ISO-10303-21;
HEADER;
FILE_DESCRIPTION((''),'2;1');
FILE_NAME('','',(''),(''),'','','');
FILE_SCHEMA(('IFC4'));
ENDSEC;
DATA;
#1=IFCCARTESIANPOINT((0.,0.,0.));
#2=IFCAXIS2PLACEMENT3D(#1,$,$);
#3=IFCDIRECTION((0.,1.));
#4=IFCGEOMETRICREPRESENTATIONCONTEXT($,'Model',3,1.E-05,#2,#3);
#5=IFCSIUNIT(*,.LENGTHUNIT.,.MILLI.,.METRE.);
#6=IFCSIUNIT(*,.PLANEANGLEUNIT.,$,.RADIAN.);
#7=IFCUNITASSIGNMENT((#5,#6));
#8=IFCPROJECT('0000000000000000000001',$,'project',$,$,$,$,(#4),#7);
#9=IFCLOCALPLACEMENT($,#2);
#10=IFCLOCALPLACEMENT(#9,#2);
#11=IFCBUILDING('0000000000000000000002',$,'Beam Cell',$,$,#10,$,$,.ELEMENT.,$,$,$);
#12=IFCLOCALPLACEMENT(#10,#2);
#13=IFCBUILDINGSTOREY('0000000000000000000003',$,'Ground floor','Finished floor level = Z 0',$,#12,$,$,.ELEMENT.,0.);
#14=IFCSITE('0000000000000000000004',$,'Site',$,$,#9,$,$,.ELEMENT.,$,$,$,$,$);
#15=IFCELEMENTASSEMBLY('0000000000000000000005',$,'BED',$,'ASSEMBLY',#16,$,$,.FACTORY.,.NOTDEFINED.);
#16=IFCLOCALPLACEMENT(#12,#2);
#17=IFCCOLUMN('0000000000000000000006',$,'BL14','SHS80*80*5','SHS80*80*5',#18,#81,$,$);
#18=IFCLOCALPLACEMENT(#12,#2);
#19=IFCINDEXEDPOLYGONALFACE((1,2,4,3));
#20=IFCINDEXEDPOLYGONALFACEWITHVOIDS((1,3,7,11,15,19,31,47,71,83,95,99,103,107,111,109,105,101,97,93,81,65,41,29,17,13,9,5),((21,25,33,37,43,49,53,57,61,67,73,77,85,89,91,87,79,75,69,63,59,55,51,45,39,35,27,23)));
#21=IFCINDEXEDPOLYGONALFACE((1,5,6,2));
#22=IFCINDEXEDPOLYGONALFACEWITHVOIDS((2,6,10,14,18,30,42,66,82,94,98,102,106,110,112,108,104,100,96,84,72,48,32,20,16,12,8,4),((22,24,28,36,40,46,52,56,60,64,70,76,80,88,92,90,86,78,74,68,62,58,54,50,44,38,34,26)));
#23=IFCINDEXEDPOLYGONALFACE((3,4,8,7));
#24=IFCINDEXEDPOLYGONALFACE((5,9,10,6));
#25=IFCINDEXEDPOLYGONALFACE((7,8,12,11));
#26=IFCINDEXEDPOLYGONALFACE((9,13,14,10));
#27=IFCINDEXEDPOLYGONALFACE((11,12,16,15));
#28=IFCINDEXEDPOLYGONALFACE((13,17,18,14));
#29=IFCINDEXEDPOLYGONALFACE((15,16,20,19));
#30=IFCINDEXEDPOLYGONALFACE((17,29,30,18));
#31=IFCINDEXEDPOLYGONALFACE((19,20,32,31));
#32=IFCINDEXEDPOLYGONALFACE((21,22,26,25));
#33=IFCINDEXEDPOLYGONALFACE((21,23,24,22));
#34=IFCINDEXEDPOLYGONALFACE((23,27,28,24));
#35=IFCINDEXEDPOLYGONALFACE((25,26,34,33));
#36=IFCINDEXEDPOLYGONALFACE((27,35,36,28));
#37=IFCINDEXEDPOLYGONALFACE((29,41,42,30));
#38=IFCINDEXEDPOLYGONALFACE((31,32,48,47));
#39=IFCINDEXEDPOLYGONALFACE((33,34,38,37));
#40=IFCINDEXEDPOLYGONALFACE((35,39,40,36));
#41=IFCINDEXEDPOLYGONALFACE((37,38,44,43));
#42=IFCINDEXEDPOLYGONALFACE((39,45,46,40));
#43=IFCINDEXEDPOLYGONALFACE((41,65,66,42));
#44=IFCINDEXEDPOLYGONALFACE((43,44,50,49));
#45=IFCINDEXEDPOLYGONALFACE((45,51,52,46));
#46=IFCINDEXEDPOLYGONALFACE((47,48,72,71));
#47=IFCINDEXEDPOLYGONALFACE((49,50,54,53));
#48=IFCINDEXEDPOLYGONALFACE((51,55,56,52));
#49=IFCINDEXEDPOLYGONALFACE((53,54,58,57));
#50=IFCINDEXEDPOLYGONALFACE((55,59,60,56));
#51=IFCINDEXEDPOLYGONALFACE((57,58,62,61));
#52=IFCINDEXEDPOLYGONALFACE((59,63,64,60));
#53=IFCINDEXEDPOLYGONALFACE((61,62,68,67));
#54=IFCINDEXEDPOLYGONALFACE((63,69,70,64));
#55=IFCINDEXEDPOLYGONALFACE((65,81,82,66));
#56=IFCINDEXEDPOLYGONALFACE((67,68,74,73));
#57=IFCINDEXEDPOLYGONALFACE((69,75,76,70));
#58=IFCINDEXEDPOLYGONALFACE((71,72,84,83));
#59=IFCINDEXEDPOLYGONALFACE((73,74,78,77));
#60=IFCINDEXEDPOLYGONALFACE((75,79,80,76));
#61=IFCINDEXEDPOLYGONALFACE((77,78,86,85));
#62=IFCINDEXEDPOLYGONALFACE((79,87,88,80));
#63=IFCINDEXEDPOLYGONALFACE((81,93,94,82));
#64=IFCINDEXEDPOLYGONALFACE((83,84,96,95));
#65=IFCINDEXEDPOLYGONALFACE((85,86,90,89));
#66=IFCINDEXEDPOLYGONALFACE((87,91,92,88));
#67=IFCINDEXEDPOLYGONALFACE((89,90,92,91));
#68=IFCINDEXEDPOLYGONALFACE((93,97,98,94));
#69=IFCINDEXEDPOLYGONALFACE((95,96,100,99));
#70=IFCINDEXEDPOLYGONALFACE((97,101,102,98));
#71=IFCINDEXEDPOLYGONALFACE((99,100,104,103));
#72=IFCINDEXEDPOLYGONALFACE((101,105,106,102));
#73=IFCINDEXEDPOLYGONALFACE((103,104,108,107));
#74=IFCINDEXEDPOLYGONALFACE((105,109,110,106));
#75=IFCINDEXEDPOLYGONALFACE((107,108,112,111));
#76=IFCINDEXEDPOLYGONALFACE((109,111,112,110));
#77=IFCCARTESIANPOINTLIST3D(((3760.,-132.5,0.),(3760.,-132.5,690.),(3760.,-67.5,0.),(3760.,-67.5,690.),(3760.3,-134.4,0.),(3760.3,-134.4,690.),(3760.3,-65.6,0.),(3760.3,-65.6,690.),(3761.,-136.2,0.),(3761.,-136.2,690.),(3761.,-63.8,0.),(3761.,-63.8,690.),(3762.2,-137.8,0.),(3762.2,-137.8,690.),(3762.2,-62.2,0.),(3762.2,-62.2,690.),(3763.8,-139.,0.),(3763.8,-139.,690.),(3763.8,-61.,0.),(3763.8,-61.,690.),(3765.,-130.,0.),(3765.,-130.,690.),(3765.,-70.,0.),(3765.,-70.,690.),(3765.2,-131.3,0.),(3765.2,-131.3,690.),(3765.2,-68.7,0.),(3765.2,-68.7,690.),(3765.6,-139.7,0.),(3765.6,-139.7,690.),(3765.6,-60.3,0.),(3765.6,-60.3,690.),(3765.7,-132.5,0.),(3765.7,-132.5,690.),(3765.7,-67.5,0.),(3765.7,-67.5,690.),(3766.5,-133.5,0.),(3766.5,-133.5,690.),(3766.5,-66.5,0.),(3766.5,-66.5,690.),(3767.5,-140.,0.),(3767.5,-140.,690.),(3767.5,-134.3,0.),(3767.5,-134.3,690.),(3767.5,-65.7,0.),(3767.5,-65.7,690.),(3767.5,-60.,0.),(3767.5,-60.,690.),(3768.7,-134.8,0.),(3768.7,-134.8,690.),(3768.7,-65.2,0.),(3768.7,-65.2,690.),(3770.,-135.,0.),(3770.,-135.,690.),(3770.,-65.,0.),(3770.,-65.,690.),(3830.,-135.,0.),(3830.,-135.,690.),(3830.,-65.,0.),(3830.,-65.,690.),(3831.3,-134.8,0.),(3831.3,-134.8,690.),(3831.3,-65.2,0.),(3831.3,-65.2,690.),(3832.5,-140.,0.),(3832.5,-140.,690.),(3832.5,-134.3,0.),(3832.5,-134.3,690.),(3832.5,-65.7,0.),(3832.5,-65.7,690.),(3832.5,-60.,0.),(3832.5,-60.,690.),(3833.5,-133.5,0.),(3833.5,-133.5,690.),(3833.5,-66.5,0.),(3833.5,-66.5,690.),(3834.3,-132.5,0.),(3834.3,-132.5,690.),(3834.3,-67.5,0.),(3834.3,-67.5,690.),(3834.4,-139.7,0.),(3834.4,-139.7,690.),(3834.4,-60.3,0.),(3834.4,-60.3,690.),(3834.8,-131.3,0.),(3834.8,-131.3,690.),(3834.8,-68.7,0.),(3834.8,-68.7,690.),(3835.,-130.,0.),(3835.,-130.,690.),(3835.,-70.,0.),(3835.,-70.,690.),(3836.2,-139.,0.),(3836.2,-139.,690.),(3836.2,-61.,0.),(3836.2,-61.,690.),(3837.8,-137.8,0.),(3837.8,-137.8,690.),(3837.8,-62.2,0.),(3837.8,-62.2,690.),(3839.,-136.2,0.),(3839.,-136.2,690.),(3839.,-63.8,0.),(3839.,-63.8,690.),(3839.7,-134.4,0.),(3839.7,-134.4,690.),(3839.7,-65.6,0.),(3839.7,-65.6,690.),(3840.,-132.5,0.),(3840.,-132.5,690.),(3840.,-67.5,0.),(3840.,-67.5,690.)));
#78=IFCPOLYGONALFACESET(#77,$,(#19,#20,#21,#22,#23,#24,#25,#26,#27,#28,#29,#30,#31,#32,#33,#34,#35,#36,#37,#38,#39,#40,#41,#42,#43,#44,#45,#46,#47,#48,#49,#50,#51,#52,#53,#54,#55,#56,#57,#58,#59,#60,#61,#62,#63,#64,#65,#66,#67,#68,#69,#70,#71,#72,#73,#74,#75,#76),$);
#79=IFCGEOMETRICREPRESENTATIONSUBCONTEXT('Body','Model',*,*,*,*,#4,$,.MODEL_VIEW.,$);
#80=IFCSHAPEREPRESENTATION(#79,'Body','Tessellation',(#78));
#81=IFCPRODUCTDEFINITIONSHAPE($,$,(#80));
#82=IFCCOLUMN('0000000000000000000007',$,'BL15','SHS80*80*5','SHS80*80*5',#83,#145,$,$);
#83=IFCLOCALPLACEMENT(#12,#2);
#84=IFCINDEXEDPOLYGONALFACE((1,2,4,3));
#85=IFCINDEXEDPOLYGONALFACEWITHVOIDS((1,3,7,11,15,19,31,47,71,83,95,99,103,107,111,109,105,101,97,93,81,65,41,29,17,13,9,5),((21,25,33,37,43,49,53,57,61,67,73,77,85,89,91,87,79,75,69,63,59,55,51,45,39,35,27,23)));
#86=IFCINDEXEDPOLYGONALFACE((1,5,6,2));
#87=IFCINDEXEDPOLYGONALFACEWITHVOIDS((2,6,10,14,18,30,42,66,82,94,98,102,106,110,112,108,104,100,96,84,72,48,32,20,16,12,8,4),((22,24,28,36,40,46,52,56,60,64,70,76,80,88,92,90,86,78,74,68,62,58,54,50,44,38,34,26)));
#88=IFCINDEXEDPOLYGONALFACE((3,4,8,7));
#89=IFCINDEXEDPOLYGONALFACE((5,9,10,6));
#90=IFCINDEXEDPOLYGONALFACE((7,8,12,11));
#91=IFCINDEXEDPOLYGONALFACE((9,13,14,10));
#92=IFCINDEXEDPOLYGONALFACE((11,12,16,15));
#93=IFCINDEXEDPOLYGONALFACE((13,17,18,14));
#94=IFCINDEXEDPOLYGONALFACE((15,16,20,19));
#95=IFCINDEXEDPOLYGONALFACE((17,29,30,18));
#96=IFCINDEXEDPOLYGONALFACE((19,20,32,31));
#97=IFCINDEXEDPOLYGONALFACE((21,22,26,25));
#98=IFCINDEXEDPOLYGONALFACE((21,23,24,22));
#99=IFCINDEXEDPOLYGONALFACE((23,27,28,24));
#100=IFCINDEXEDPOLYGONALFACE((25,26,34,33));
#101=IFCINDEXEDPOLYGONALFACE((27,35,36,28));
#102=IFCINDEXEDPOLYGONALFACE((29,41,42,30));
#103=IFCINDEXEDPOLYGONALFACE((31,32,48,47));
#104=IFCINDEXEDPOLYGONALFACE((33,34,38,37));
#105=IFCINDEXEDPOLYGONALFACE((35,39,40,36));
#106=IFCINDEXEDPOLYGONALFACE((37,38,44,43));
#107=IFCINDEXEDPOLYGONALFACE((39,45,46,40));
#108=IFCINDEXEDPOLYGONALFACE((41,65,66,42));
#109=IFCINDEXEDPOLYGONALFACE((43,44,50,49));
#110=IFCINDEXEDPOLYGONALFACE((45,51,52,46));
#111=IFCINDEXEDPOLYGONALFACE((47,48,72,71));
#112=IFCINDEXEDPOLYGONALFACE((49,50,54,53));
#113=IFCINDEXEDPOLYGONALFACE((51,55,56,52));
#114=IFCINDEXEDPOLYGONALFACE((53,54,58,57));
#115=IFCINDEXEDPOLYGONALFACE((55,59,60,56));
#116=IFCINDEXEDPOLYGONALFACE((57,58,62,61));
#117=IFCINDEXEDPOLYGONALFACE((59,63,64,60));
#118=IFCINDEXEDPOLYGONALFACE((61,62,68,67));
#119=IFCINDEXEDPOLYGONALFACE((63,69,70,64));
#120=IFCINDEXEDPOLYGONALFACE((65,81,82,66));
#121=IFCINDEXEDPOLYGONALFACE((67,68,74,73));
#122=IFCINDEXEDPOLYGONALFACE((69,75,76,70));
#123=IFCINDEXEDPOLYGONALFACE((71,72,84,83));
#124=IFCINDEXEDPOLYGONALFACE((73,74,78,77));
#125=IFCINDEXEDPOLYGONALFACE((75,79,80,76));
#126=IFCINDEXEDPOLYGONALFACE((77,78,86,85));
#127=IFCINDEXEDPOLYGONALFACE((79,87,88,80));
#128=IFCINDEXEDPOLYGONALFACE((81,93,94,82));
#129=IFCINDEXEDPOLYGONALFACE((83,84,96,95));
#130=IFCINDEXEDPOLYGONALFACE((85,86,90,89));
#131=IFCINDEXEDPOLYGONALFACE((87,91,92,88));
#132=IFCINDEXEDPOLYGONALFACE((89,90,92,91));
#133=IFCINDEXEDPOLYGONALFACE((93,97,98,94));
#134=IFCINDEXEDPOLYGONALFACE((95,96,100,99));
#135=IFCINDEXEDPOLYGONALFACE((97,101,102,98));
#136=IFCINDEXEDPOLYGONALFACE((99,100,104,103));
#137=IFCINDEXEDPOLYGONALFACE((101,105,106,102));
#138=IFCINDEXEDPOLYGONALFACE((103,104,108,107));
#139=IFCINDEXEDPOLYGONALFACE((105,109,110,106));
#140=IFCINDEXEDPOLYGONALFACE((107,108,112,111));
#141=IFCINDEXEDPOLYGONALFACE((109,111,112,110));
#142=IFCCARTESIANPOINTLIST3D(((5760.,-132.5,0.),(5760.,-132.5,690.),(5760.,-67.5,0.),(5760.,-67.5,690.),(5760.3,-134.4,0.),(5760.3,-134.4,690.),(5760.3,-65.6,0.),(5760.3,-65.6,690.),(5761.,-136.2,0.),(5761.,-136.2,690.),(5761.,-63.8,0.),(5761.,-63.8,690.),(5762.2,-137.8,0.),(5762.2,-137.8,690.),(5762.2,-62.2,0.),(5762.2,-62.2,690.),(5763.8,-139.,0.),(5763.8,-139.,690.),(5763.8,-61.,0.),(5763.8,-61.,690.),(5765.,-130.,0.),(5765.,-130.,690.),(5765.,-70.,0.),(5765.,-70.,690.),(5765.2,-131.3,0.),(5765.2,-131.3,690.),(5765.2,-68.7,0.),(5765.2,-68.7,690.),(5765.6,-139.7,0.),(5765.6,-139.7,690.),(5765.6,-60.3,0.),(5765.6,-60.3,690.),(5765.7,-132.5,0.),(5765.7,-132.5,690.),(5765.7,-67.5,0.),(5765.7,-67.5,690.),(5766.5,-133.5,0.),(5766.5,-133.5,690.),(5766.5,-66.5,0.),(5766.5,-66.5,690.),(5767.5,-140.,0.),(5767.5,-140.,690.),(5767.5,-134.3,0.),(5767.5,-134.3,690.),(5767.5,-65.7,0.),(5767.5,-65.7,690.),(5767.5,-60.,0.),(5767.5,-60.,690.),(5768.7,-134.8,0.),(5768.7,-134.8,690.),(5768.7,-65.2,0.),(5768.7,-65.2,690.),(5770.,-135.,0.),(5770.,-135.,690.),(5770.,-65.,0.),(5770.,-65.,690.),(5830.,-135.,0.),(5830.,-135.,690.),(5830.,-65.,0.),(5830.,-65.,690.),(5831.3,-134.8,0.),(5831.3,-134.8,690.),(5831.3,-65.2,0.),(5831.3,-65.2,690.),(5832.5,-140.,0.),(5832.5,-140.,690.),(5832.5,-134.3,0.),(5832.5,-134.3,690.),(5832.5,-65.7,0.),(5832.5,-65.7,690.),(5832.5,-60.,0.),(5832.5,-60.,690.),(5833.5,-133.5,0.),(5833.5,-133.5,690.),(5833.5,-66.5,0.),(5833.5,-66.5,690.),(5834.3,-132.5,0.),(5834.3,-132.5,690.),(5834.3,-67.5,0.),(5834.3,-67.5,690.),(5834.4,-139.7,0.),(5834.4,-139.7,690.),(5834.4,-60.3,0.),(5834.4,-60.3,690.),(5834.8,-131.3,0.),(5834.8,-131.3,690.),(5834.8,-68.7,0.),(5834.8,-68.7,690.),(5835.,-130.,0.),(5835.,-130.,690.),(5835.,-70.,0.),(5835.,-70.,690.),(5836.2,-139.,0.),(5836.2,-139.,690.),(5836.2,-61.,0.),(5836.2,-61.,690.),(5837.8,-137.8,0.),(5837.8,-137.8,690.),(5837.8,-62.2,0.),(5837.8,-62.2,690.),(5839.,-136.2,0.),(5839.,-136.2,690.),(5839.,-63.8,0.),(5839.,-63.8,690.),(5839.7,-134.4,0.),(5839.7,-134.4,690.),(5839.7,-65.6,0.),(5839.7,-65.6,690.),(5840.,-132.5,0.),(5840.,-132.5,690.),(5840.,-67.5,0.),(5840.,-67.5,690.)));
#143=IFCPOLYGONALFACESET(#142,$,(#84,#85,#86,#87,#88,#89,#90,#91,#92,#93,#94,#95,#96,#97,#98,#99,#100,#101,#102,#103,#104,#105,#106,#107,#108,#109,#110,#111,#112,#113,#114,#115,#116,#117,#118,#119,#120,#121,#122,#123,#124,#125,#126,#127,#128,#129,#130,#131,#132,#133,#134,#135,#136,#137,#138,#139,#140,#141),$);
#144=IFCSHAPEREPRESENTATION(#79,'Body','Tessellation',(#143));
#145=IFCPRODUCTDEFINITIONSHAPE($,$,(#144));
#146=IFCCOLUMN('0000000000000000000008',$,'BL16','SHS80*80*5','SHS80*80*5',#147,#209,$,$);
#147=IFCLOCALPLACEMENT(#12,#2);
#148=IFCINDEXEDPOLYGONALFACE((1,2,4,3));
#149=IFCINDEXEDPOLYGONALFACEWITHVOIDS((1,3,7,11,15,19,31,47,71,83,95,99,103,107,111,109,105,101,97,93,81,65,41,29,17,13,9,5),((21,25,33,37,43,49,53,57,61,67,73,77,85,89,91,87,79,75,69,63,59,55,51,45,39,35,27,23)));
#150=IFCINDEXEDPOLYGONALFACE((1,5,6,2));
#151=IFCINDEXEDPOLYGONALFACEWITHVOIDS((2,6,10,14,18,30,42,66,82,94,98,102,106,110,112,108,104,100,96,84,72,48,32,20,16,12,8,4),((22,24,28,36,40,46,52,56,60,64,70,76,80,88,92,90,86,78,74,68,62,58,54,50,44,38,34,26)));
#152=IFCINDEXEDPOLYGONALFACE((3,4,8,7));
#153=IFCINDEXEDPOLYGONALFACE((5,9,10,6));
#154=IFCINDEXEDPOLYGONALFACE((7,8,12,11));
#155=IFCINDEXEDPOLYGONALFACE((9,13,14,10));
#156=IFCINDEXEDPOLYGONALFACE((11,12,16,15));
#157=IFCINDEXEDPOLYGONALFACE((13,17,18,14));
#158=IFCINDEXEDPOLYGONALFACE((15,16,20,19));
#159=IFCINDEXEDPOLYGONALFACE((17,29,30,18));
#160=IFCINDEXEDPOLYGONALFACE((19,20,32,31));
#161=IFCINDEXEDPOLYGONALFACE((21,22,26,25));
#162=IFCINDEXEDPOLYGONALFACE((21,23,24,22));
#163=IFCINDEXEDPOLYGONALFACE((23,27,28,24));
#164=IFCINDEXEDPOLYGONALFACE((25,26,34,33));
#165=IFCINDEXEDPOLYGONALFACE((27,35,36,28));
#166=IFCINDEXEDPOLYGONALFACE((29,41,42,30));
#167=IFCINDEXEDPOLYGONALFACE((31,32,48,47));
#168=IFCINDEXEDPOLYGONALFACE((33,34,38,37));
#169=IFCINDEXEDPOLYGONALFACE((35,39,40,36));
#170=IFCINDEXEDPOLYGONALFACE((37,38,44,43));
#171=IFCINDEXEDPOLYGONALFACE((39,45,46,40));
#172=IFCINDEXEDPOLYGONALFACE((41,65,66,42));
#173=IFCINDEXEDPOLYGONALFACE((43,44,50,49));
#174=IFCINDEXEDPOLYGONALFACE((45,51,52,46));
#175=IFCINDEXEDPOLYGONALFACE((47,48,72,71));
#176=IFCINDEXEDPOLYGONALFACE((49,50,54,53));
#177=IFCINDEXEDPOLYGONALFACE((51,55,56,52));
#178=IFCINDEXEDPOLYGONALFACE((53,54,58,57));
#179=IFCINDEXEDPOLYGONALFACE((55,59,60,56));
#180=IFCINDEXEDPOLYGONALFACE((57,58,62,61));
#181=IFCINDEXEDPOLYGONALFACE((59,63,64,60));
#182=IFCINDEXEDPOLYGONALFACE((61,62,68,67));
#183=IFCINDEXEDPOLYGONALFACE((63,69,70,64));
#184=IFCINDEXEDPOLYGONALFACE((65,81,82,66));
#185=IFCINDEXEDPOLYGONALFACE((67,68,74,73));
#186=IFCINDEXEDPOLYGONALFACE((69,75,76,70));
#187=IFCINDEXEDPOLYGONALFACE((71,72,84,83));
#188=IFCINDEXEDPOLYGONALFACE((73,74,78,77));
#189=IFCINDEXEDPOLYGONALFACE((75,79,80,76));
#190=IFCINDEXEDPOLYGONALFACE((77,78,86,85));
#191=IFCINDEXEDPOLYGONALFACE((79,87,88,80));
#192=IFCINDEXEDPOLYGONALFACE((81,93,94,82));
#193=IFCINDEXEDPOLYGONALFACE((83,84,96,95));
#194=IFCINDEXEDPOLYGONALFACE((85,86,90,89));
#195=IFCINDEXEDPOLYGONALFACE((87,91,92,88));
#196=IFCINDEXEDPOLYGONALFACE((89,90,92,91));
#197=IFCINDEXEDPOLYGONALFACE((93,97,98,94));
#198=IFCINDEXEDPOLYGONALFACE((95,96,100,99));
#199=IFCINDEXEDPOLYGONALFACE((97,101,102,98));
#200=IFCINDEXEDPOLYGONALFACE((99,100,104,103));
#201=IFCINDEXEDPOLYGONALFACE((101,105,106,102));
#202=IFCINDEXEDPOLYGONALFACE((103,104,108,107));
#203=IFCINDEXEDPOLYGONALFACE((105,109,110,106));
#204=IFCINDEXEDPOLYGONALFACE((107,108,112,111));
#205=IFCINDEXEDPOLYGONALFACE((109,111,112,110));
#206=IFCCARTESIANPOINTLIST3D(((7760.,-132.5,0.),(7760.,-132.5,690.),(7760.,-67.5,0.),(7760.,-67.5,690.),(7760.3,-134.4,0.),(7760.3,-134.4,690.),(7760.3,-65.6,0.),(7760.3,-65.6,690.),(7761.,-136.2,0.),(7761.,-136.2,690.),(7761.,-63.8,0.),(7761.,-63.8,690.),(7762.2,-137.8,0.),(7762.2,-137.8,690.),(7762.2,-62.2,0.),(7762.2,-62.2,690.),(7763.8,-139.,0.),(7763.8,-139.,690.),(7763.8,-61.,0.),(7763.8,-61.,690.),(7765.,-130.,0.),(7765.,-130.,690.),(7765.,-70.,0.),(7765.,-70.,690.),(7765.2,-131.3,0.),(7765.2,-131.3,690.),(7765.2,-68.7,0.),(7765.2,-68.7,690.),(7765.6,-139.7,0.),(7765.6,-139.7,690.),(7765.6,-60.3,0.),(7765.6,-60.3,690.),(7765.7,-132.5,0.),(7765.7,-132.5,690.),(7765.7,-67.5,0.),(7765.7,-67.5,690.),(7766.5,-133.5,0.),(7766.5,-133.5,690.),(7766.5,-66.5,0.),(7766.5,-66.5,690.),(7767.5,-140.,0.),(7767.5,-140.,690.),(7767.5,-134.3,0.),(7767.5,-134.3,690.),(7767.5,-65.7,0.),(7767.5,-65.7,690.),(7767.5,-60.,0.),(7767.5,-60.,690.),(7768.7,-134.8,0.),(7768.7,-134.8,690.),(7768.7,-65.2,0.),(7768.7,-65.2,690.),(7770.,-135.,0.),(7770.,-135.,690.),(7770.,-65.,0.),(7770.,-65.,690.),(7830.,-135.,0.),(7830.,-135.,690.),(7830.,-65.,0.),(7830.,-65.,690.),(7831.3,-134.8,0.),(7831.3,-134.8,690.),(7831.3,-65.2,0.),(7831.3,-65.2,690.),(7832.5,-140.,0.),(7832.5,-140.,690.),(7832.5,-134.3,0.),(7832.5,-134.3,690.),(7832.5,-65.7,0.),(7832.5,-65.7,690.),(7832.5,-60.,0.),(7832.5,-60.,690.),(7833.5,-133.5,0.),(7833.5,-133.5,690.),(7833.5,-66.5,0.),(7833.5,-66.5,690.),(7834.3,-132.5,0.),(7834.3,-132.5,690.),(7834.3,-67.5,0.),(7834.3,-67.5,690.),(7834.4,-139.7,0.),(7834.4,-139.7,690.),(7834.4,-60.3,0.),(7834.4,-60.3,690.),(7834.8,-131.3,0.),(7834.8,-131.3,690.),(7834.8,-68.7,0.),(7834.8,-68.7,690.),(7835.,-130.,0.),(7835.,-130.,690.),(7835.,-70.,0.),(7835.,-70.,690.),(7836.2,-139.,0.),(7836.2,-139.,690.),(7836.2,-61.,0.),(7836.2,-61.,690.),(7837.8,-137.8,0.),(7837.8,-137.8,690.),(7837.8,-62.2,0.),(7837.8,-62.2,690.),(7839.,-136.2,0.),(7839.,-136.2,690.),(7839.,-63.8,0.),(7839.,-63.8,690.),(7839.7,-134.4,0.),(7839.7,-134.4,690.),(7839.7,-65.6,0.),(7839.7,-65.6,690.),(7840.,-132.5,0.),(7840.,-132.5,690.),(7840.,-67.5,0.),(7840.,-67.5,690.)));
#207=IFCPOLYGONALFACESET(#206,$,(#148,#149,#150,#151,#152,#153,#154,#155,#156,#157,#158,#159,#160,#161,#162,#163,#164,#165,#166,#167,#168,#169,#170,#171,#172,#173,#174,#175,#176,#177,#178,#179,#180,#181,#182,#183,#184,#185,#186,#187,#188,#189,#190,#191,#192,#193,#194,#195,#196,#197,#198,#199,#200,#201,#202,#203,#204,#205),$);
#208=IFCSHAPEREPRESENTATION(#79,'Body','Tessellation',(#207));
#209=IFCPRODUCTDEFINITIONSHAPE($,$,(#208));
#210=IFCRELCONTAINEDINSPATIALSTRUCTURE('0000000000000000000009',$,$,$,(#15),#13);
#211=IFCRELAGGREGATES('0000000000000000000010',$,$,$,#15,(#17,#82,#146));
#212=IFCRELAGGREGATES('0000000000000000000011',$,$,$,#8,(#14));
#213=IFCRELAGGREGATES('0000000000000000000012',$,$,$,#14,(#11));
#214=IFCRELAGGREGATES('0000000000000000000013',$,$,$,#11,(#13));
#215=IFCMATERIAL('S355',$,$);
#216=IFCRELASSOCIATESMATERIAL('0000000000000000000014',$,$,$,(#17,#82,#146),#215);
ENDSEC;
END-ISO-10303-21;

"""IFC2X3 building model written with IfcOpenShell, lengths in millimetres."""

from ifc_helpers import new_model, si_unit, direction, frame, origin, origin_2d, place, context, subcontext, project, spatial, hollow_rectangle, extrude, material, element, aggregate, save


model = new_model("IFC2X3")

# Units and contexts
model_context = context("Model", 3, precision=1e-05, world=origin(), true_north=direction((0.0, 1.0)))
body_context = subcontext(model_context, "Body", "Model", "MODEL_VIEW")
ifc_project = project(units=[si_unit("LENGTHUNIT", "METRE", prefix="MILLI"), si_unit("PLANEANGLEUNIT", "RADIAN")], contexts=[model_context])

# Site, building, storey
site_placement = place(None, origin())
site = spatial("IfcSite", under=ifc_project, at=site_placement, Name="Site", CompositionType="ELEMENT")
building_placement = place(site_placement, origin())
building = spatial("IfcBuilding", under=site, at=building_placement, Name="Beam Cell", CompositionType="ELEMENT")
storey_placement = place(building_placement, origin())
storey = spatial("IfcBuildingStorey", under=building, at=storey_placement, Name="Ground floor", Description="Finished floor level = Z 0", CompositionType="ELEMENT", Elevation=0.0)

# Element assembly, columns
ifc_material = material(Name="S355")
assembly_1_placement = place(storey_placement, origin())
assembly_1 = element("IfcElementAssembly", 1, at=assembly_1_placement, inside=storey, Name="BED", ObjectType="ASSEMBLY", AssemblyPlace="FACTORY", PredefinedType="NOTDEFINED")
column_1_placement = place(storey_placement, frame((3800.0, -100.0, 0.0), z_axis=(0.0, 0.0, 1.0), x_axis=(1.0, 0.0, 0.0)))
column_1 = element("IfcColumn", 2, at=column_1_placement, material=ifc_material, Name="BL14", Description="SHS80*80*5", ObjectType="SHS80*80*5", context=body_context, shape_type="SweptSolid", body=[
    extrude(hollow_rectangle(XDim=80.0, YDim=80.0, WallThickness=5.0, InnerFilletRadius=5.0, OuterFilletRadius=7.5, at=origin_2d()), origin(), (0.0, 0.0, 1.0), 690.0),
])
column_2_placement = place(storey_placement, frame((5800.0, -100.0, 0.0), z_axis=(0.0, 0.0, 1.0), x_axis=(1.0, 0.0, 0.0)))
column_2 = element("IfcColumn", 3, at=column_2_placement, material=ifc_material, Name="BL15", Description="SHS80*80*5", ObjectType="SHS80*80*5", context=body_context, shape_type="SweptSolid", body=[
    extrude(hollow_rectangle(XDim=80.0, YDim=80.0, WallThickness=5.0, InnerFilletRadius=5.0, OuterFilletRadius=7.5, at=origin_2d()), origin(), (0.0, 0.0, 1.0), 690.0),
])
column_3_placement = place(storey_placement, frame((7800.0, -100.0, 0.0), z_axis=(0.0, 0.0, 1.0), x_axis=(1.0, 0.0, 0.0)))
column_3 = element("IfcColumn", 4, at=column_3_placement, material=ifc_material, Name="BL16", Description="SHS80*80*5", ObjectType="SHS80*80*5", context=body_context, shape_type="SweptSolid", body=[
    extrude(hollow_rectangle(XDim=80.0, YDim=80.0, WallThickness=5.0, InnerFilletRadius=5.0, OuterFilletRadius=7.5, at=origin_2d()), origin(), (0.0, 0.0, 1.0), 690.0),
])
aggregate(assembly_1, [column_1, column_2, column_3])

save(model, "model.ifc")
